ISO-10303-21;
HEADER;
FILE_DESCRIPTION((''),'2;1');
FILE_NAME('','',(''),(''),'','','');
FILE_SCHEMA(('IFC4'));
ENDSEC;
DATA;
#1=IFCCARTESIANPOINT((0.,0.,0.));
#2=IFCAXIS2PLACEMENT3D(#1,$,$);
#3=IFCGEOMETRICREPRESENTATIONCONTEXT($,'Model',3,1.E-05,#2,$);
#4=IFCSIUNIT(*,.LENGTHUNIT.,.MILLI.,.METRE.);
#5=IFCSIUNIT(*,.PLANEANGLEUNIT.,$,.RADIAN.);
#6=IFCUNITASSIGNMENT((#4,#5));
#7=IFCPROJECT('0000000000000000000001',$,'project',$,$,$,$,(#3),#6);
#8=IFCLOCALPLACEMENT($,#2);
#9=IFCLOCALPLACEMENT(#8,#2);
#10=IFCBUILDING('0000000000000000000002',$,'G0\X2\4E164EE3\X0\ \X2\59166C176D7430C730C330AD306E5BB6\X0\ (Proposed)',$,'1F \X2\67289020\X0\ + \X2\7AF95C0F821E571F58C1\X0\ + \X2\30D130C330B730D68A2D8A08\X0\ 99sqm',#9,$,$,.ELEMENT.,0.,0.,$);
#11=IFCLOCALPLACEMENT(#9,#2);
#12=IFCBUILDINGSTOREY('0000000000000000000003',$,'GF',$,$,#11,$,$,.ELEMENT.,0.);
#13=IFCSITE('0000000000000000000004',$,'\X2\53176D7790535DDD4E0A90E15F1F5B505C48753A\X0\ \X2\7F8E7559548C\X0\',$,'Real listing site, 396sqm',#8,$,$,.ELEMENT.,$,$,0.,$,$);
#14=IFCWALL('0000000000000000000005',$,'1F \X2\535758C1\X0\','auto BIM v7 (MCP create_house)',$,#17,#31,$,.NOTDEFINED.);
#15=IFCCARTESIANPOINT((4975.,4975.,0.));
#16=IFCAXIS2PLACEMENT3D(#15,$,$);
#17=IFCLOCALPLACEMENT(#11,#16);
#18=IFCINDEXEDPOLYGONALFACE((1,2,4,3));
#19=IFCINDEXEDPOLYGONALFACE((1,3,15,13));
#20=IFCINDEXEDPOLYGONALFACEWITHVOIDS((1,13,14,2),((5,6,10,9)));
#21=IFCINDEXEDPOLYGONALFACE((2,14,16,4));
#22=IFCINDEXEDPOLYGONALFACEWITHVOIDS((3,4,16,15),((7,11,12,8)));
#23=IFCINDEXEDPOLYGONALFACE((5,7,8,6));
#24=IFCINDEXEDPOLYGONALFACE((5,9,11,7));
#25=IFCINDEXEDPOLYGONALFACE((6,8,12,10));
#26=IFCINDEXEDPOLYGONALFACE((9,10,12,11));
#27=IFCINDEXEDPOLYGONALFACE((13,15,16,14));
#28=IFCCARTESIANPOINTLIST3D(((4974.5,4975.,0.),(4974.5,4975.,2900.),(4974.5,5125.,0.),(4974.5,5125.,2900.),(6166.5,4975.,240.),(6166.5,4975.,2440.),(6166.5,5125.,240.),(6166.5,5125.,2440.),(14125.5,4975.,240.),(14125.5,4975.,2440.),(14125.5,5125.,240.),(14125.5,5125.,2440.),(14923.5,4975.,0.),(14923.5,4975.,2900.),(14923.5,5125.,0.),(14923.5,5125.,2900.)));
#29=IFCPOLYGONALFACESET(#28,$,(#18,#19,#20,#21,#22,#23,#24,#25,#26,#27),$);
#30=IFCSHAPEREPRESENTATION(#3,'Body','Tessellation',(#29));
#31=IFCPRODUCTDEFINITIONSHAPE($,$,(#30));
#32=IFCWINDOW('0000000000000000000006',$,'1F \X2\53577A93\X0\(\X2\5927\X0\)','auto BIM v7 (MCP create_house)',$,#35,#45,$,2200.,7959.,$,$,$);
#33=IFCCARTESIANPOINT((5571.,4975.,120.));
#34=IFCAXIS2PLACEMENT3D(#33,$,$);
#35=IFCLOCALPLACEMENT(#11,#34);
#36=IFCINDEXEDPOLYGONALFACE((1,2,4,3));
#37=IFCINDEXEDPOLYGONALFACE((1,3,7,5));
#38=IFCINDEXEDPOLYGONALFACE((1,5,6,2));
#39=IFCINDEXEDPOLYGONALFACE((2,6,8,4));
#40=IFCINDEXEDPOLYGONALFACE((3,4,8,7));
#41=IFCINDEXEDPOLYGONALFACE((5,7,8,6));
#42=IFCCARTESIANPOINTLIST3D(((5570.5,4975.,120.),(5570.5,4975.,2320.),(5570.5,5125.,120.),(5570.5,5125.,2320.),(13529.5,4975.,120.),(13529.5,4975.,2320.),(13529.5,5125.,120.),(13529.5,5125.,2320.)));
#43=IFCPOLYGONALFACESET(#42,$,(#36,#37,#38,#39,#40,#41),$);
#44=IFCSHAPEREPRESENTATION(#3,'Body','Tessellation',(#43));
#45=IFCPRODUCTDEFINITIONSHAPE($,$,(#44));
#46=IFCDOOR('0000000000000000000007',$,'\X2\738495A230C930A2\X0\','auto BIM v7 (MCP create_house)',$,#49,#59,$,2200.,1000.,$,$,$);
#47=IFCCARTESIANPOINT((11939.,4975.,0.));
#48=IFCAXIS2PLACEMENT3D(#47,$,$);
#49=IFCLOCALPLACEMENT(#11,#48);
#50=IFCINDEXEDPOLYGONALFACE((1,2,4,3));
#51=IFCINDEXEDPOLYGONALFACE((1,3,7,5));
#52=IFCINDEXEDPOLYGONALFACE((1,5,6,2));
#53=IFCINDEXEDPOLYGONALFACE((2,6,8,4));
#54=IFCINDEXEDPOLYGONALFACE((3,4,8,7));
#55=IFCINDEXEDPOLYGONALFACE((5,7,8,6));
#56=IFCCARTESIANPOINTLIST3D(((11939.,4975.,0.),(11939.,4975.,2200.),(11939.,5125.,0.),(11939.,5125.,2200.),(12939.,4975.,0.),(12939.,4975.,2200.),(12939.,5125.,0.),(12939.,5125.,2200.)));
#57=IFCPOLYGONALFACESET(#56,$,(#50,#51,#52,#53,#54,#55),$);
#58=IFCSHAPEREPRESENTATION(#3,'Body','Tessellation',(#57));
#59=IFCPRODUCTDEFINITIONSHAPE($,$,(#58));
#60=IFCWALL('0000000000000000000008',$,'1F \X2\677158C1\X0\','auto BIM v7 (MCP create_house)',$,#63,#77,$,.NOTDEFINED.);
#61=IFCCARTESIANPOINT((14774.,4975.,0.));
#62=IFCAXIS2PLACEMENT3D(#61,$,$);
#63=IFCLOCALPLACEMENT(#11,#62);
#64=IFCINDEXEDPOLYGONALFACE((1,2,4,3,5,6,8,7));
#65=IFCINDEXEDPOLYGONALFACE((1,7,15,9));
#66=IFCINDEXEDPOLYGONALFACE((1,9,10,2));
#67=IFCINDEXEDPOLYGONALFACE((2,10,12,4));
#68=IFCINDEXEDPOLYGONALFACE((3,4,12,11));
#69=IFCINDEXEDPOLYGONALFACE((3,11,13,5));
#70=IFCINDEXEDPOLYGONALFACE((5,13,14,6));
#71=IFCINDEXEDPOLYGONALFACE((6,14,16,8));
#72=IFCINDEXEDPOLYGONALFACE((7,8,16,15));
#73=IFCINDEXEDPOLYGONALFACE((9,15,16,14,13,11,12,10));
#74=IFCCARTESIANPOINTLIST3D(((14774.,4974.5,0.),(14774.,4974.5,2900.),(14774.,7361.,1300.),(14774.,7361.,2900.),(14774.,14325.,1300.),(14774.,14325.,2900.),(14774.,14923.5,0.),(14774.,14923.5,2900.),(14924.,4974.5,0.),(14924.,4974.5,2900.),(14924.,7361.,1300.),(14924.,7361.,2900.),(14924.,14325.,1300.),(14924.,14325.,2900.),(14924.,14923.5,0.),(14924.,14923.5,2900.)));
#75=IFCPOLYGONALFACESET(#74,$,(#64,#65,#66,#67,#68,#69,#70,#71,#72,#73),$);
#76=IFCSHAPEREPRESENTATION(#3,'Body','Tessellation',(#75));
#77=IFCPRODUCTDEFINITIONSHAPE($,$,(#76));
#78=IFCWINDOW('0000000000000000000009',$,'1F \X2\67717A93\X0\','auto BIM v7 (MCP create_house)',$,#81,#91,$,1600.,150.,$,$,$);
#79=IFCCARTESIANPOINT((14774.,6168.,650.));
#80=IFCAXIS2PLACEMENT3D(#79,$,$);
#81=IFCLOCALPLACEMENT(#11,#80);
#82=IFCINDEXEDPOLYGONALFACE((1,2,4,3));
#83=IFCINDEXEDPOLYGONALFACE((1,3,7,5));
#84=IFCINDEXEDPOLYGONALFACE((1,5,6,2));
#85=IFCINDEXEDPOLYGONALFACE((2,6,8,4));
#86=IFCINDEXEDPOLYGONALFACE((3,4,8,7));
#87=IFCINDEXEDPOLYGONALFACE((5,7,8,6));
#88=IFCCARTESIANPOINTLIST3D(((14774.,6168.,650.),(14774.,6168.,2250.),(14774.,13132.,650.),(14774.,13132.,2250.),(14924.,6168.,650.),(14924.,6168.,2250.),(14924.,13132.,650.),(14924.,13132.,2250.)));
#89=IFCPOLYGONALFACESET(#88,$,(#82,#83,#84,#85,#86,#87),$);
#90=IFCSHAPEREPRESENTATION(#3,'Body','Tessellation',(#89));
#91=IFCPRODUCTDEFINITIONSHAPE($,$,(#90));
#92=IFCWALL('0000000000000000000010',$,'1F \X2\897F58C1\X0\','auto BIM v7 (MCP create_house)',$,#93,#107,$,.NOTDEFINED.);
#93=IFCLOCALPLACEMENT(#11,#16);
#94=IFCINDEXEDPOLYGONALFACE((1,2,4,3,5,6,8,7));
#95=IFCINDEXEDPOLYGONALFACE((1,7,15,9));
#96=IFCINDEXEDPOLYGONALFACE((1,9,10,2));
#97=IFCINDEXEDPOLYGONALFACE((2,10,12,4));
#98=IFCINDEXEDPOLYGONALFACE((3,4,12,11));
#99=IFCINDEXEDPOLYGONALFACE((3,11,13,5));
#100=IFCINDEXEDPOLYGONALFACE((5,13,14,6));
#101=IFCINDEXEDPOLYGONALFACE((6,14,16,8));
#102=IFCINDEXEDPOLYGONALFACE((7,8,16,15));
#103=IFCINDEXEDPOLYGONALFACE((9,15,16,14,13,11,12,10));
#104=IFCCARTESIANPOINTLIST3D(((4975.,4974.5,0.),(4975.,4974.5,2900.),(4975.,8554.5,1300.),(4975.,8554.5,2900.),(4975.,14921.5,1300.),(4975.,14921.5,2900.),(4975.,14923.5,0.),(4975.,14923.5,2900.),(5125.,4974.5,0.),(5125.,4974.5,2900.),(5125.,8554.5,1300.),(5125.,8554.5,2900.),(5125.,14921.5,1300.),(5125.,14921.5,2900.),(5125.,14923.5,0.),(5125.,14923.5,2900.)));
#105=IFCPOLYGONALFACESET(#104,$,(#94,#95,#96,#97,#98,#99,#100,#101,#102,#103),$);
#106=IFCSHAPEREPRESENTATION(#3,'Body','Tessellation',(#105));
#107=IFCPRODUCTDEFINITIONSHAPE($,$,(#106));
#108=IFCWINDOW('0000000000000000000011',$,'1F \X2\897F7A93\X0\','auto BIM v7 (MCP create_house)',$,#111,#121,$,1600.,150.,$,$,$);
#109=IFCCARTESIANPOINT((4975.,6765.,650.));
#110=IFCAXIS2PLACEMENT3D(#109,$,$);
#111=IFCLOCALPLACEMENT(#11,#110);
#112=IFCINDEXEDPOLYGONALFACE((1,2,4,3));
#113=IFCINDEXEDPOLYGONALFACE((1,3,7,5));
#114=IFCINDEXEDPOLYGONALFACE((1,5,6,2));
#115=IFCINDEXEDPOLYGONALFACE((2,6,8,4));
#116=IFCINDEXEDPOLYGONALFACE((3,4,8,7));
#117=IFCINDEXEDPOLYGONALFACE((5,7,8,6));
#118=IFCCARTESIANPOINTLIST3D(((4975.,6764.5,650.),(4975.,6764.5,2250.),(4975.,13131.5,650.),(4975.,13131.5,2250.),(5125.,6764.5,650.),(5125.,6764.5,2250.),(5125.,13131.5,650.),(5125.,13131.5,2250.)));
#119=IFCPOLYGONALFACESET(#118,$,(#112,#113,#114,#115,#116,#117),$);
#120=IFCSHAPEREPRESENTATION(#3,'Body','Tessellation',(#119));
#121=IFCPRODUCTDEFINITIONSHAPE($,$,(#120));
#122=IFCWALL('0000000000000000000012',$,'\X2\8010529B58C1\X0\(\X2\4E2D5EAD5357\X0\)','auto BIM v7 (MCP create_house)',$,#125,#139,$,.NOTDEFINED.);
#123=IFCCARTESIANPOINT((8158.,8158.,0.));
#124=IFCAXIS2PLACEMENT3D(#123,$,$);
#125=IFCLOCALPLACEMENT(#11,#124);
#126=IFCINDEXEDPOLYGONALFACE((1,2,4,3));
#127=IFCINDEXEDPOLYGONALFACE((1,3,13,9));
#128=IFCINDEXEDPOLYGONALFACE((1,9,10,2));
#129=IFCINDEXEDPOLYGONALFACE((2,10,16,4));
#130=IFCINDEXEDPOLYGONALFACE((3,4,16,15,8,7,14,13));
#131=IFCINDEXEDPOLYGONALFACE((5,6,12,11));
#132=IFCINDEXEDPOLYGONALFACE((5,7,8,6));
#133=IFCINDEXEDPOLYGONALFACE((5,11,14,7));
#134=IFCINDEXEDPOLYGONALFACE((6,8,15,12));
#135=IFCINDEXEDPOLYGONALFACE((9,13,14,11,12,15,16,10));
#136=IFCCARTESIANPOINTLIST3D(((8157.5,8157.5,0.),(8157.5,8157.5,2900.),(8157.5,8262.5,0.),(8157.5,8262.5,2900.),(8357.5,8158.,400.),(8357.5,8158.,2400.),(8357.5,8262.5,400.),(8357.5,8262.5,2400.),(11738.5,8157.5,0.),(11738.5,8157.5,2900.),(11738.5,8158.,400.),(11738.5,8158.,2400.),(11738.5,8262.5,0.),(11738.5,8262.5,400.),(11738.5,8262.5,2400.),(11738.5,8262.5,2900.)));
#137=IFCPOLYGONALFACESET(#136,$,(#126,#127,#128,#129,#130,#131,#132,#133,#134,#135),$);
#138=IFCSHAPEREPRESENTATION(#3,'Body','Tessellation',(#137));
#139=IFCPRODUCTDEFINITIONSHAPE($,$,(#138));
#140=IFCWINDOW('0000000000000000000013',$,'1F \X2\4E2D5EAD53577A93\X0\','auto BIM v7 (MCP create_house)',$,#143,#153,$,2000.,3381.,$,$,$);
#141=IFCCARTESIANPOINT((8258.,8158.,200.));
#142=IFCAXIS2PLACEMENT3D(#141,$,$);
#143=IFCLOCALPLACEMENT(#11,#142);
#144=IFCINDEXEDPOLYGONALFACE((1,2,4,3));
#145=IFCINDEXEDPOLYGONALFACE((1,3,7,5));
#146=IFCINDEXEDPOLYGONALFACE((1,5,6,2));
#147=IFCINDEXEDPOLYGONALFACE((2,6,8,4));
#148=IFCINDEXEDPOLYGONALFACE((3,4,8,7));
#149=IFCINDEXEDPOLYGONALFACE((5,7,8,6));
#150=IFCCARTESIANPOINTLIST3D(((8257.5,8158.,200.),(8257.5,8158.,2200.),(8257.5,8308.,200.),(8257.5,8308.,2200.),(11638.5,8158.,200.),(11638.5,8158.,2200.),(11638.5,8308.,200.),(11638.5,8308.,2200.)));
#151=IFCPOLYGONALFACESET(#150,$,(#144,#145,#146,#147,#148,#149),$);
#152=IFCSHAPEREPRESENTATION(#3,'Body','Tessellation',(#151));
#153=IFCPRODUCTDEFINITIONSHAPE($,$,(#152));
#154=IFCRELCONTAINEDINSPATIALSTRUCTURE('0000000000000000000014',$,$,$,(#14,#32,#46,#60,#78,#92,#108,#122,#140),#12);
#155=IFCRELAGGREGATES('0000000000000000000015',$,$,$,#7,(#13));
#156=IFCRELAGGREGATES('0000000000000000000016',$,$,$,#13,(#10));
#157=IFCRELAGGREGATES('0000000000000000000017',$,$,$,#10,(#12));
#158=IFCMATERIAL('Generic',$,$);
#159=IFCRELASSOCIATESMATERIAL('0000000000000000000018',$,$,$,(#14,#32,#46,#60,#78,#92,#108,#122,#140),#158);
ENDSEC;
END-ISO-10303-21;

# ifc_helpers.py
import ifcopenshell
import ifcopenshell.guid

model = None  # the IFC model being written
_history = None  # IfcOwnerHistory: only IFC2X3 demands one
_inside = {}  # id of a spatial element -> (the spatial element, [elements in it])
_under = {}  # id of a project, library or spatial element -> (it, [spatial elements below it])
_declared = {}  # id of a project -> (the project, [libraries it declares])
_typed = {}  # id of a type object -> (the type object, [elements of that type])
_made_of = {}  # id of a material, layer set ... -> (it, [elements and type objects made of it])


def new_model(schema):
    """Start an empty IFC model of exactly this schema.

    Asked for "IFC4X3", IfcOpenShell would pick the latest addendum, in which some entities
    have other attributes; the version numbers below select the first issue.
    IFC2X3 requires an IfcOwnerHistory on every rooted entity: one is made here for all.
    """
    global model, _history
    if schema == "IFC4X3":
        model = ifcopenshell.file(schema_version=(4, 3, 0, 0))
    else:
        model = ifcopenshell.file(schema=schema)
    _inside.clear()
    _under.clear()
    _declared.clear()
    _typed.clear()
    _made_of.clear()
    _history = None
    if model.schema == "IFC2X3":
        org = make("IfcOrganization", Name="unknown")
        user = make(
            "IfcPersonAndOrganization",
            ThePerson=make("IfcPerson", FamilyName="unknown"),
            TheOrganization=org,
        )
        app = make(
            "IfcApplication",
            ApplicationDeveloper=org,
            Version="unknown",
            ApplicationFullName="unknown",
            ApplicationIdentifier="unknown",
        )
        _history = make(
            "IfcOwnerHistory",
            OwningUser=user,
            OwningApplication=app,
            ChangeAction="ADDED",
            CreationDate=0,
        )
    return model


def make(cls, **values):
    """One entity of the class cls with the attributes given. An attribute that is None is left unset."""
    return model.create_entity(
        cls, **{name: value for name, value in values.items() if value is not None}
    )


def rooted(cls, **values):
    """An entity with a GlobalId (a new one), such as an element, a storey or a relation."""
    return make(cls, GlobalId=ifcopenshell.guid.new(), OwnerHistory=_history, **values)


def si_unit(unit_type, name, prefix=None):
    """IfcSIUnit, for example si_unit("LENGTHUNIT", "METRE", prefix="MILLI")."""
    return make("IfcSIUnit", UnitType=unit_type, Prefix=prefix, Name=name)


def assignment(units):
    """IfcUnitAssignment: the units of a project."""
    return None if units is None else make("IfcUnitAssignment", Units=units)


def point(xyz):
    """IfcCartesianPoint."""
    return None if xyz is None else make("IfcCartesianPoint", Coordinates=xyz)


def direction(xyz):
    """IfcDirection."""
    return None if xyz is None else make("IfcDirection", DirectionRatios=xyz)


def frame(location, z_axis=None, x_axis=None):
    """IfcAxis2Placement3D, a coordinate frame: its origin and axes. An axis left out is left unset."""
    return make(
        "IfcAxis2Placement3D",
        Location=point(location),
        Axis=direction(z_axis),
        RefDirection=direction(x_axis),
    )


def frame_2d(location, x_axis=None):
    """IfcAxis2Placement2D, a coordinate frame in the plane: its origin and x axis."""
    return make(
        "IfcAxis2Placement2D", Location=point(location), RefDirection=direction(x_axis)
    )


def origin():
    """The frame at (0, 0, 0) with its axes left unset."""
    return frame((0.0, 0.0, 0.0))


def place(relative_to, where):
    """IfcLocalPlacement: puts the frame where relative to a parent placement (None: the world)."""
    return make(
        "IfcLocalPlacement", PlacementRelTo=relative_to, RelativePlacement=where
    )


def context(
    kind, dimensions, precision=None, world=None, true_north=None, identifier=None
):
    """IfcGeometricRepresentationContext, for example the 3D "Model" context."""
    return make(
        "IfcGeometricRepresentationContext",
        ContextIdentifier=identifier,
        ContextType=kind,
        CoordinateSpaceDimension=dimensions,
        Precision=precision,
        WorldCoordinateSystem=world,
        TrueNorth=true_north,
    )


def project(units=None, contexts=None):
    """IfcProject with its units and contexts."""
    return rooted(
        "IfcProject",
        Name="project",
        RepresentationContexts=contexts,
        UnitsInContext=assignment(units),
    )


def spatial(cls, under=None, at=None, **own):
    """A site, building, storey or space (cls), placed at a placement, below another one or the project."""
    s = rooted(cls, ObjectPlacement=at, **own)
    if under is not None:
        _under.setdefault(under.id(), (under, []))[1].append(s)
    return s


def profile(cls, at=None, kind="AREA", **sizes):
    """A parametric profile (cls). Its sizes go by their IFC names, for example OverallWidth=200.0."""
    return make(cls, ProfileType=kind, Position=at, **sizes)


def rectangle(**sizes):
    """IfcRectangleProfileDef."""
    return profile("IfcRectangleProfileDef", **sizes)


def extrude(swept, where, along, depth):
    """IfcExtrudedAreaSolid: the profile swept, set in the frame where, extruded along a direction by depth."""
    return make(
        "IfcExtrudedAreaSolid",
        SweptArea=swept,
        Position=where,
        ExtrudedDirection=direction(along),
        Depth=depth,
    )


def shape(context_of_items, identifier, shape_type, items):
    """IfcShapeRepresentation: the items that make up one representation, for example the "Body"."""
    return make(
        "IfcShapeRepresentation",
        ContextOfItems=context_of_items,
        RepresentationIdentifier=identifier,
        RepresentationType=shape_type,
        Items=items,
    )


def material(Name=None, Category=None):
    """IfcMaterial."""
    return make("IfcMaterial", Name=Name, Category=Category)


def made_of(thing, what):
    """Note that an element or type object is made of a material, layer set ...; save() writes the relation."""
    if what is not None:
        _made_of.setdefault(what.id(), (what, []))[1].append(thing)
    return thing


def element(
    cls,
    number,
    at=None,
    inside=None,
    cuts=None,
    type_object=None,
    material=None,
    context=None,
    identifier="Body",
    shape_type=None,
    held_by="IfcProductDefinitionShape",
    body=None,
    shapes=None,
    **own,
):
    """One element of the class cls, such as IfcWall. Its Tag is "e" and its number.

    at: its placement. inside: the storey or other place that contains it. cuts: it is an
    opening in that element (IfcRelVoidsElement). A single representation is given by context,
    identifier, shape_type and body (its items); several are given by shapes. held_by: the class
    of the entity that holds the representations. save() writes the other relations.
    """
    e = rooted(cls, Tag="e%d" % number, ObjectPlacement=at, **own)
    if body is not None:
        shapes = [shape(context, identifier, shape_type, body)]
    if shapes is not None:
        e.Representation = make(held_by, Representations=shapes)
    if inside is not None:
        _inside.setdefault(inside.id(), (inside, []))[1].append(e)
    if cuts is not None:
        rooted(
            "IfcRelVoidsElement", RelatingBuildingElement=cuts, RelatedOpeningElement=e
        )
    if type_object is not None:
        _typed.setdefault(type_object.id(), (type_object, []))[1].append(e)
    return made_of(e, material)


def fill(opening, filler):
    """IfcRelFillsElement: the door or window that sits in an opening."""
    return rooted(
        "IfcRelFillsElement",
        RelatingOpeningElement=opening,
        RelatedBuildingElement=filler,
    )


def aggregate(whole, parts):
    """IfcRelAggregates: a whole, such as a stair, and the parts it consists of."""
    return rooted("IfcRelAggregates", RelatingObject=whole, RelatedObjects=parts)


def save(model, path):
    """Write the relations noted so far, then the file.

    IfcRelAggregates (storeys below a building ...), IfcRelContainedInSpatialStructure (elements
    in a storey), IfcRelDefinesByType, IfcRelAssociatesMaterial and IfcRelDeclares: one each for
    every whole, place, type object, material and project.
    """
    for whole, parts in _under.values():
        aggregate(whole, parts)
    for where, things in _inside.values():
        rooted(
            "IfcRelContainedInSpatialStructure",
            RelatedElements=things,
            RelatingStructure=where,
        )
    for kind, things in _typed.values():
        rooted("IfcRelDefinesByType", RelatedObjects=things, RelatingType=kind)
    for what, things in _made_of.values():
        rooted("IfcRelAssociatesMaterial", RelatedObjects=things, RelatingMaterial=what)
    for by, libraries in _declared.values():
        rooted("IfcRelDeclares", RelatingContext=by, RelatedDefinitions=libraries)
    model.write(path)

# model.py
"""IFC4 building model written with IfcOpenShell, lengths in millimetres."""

from ifc_helpers import new_model, si_unit, frame, frame_2d, origin, place, context, project, spatial, rectangle, extrude, material, element, fill, save


model = new_model("IFC4")

# Units and contexts
model_context = context("Model", 3, precision=1e-05, world=origin())
ifc_project = project(units=[si_unit("LENGTHUNIT", "METRE", prefix="MILLI"), si_unit("PLANEANGLEUNIT", "RADIAN")], contexts=[model_context])

# Site, building, storey
site_placement = place(None, origin())
site = spatial("IfcSite", under=ifc_project, at=site_placement, Name="北海道川上郡弟子屈町 美留和", ObjectType="Real listing site, 396sqm", CompositionType="ELEMENT", RefElevation=0.0)
building_placement = place(site_placement, origin())
building = spatial("IfcBuilding", under=site, at=building_placement, Name="G0世代 外気浴デッキの家 (Proposed)", ObjectType="1F 木造 + 竹小舞土壁 + パッシブ設計 99sqm", CompositionType="ELEMENT", ElevationOfRefHeight=0.0, ElevationOfTerrain=0.0)
storey_placement = place(building_placement, origin())
storey = spatial("IfcBuildingStorey", under=building, at=storey_placement, Name="GF", CompositionType="ELEMENT", Elevation=0.0)

# Shared definitions
ifc_material = material(Name="Generic")

# Wall, openings, window, door
wall_1_placement = place(storey_placement, frame((4975.0, 4975.0, 0.0)))
wall_1 = element("IfcWall", 1, at=wall_1_placement, inside=storey, material=ifc_material, Name="1F 南壁", Description="auto BIM v7 (MCP create_house)", PredefinedType="NOTDEFINED", context=model_context, shape_type="SweptSolid", body=[
    extrude(rectangle(XDim=9949.0, YDim=150.0, at=frame_2d((4974.0, 75.0))), frame((4975.0, 4975.0, 0.0)), (0.0, 0.0, 1.0), 2900.0),
])
opening_1_placement = place(storey_placement, frame((5571.0, 4975.0, 120.0)))
opening_1 = element("IfcOpeningElement", 2, at=opening_1_placement, cuts=wall_1, PredefinedType="NOTDEFINED", context=model_context, shape_type="SweptSolid", body=[
    extrude(rectangle(XDim=7959.0, YDim=150.0, at=frame_2d((3979.0, 75.0))), frame((5571.0, 4975.0, 120.0)), (0.0, 0.0, 1.0), 2200.0),
])
opening_2_placement = place(storey_placement, frame((11939.0, 4975.0, 0.0)))
opening_2 = element("IfcOpeningElement", 3, at=opening_2_placement, cuts=wall_1, PredefinedType="NOTDEFINED", context=model_context, shape_type="SweptSolid", body=[
    extrude(rectangle(XDim=1000.0, YDim=150.0, at=frame_2d((500.0, 75.0))), frame((11939.0, 4975.0, 0.0)), (0.0, 0.0, 1.0), 2200.0),
])
window_1_placement = place(storey_placement, frame((5571.0, 4975.0, 120.0)))
window_1 = element("IfcWindow", 4, at=window_1_placement, inside=storey, material=ifc_material, Name="1F 南窓(大)", Description="auto BIM v7 (MCP create_house)", OverallHeight=2200.0, OverallWidth=7959.0, context=model_context, shape_type="SweptSolid", body=[
    extrude(rectangle(XDim=7959.0, YDim=150.0, at=frame_2d((3979.0, 75.0))), frame((5571.0, 4975.0, 120.0)), (0.0, 0.0, 1.0), 2200.0),
])
fill(opening_1, window_1)
door_placement = place(storey_placement, frame((11939.0, 4975.0, 0.0)))
door = element("IfcDoor", 5, at=door_placement, inside=storey, material=ifc_material, Name="玄関ドア", Description="auto BIM v7 (MCP create_house)", OverallHeight=2200.0, OverallWidth=1000.0, context=model_context, shape_type="SweptSolid", body=[
    extrude(rectangle(XDim=1000.0, YDim=150.0, at=frame_2d((500.0, 75.0))), frame((11939.0, 4975.0, 0.0)), (0.0, 0.0, 1.0), 2200.0),
])
fill(opening_2, door)

# Walls, openings, windows
wall_2_placement = place(storey_placement, frame((14774.0, 4975.0, 0.0)))
wall_2 = element("IfcWall", 6, at=wall_2_placement, inside=storey, material=ifc_material, Name="1F 東壁", Description="auto BIM v7 (MCP create_house)", PredefinedType="NOTDEFINED", context=model_context, shape_type="SweptSolid", body=[
    extrude(rectangle(XDim=150.0, YDim=9949.0, at=frame_2d((75.0, 4974.0))), frame((14774.0, 4975.0, 0.0)), (0.0, 0.0, 1.0), 2900.0),
])
opening_3_placement = place(storey_placement, frame((14774.0, 6168.0, 650.0)))
opening_3 = element("IfcOpeningElement", 7, at=opening_3_placement, cuts=wall_2, PredefinedType="NOTDEFINED", context=model_context, shape_type="SweptSolid", body=[
    extrude(rectangle(XDim=150.0, YDim=6964.0, at=frame_2d((75.0, 3482.0))), frame((14774.0, 6168.0, 650.0)), (0.0, 0.0, 1.0), 1600.0),
])
window_2_placement = place(storey_placement, frame((14774.0, 6168.0, 650.0)))
window_2 = element("IfcWindow", 8, at=window_2_placement, inside=storey, material=ifc_material, Name="1F 東窓", Description="auto BIM v7 (MCP create_house)", OverallHeight=1600.0, OverallWidth=150.0, context=model_context, shape_type="SweptSolid", body=[
    extrude(rectangle(XDim=150.0, YDim=6964.0, at=frame_2d((75.0, 3482.0))), frame((14774.0, 6168.0, 650.0)), (0.0, 0.0, 1.0), 1600.0),
])
fill(opening_3, window_2)
wall_3_placement = place(storey_placement, frame((4975.0, 4975.0, 0.0)))
wall_3 = element("IfcWall", 9, at=wall_3_placement, inside=storey, material=ifc_material, Name="1F 西壁", Description="auto BIM v7 (MCP create_house)", PredefinedType="NOTDEFINED", context=model_context, shape_type="SweptSolid", body=[
    extrude(rectangle(XDim=150.0, YDim=9949.0, at=frame_2d((75.0, 4974.0))), frame((4975.0, 4975.0, 0.0)), (0.0, 0.0, 1.0), 2900.0),
])
opening_4_placement = place(storey_placement, frame((4975.0, 6765.0, 650.0)))
opening_4 = element("IfcOpeningElement", 10, at=opening_4_placement, cuts=wall_3, PredefinedType="NOTDEFINED", context=model_context, shape_type="SweptSolid", body=[
    extrude(rectangle(XDim=150.0, YDim=6367.0, at=frame_2d((75.0, 3183.0))), frame((4975.0, 6765.0, 650.0)), (0.0, 0.0, 1.0), 1600.0),
])
window_3_placement = place(storey_placement, frame((4975.0, 6765.0, 650.0)))
window_3 = element("IfcWindow", 11, at=window_3_placement, inside=storey, material=ifc_material, Name="1F 西窓", Description="auto BIM v7 (MCP create_house)", OverallHeight=1600.0, OverallWidth=150.0, context=model_context, shape_type="SweptSolid", body=[
    extrude(rectangle(XDim=150.0, YDim=6367.0, at=frame_2d((75.0, 3183.0))), frame((4975.0, 6765.0, 650.0)), (0.0, 0.0, 1.0), 1600.0),
])
fill(opening_4, window_3)
wall_4_placement = place(storey_placement, frame((8158.0, 8158.0, 0.0)))
wall_4 = element("IfcWall", 12, at=wall_4_placement, inside=storey, material=ifc_material, Name="耐力壁(中庭南)", Description="auto BIM v7 (MCP create_house)", PredefinedType="NOTDEFINED", context=model_context, shape_type="SweptSolid", body=[
    extrude(rectangle(XDim=3581.0, YDim=105.0, at=frame_2d((1790.0, 52.0))), frame((8158.0, 8158.0, 0.0)), (0.0, 0.0, 1.0), 2900.0),
])
opening_5_placement = place(storey_placement, frame((8258.0, 8158.0, 200.0)))
opening_5 = element("IfcOpeningElement", 13, at=opening_5_placement, cuts=wall_4, PredefinedType="NOTDEFINED", context=model_context, shape_type="SweptSolid", body=[
    extrude(rectangle(XDim=3381.0, YDim=150.0, at=frame_2d((1690.0, 75.0))), frame((8258.0, 8158.0, 200.0)), (0.0, 0.0, 1.0), 2000.0),
])
window_4_placement = place(storey_placement, frame((8258.0, 8158.0, 200.0)))
window_4 = element("IfcWindow", 14, at=window_4_placement, inside=storey, material=ifc_material, Name="1F 中庭南窓", Description="auto BIM v7 (MCP create_house)", OverallHeight=2000.0, OverallWidth=3381.0, context=model_context, shape_type="SweptSolid", body=[
    extrude(rectangle(XDim=3381.0, YDim=150.0, at=frame_2d((1690.0, 75.0))), frame((8258.0, 8158.0, 200.0)), (0.0, 0.0, 1.0), 2000.0),
])
fill(opening_5, window_4)

save(model, "model.ifc")
